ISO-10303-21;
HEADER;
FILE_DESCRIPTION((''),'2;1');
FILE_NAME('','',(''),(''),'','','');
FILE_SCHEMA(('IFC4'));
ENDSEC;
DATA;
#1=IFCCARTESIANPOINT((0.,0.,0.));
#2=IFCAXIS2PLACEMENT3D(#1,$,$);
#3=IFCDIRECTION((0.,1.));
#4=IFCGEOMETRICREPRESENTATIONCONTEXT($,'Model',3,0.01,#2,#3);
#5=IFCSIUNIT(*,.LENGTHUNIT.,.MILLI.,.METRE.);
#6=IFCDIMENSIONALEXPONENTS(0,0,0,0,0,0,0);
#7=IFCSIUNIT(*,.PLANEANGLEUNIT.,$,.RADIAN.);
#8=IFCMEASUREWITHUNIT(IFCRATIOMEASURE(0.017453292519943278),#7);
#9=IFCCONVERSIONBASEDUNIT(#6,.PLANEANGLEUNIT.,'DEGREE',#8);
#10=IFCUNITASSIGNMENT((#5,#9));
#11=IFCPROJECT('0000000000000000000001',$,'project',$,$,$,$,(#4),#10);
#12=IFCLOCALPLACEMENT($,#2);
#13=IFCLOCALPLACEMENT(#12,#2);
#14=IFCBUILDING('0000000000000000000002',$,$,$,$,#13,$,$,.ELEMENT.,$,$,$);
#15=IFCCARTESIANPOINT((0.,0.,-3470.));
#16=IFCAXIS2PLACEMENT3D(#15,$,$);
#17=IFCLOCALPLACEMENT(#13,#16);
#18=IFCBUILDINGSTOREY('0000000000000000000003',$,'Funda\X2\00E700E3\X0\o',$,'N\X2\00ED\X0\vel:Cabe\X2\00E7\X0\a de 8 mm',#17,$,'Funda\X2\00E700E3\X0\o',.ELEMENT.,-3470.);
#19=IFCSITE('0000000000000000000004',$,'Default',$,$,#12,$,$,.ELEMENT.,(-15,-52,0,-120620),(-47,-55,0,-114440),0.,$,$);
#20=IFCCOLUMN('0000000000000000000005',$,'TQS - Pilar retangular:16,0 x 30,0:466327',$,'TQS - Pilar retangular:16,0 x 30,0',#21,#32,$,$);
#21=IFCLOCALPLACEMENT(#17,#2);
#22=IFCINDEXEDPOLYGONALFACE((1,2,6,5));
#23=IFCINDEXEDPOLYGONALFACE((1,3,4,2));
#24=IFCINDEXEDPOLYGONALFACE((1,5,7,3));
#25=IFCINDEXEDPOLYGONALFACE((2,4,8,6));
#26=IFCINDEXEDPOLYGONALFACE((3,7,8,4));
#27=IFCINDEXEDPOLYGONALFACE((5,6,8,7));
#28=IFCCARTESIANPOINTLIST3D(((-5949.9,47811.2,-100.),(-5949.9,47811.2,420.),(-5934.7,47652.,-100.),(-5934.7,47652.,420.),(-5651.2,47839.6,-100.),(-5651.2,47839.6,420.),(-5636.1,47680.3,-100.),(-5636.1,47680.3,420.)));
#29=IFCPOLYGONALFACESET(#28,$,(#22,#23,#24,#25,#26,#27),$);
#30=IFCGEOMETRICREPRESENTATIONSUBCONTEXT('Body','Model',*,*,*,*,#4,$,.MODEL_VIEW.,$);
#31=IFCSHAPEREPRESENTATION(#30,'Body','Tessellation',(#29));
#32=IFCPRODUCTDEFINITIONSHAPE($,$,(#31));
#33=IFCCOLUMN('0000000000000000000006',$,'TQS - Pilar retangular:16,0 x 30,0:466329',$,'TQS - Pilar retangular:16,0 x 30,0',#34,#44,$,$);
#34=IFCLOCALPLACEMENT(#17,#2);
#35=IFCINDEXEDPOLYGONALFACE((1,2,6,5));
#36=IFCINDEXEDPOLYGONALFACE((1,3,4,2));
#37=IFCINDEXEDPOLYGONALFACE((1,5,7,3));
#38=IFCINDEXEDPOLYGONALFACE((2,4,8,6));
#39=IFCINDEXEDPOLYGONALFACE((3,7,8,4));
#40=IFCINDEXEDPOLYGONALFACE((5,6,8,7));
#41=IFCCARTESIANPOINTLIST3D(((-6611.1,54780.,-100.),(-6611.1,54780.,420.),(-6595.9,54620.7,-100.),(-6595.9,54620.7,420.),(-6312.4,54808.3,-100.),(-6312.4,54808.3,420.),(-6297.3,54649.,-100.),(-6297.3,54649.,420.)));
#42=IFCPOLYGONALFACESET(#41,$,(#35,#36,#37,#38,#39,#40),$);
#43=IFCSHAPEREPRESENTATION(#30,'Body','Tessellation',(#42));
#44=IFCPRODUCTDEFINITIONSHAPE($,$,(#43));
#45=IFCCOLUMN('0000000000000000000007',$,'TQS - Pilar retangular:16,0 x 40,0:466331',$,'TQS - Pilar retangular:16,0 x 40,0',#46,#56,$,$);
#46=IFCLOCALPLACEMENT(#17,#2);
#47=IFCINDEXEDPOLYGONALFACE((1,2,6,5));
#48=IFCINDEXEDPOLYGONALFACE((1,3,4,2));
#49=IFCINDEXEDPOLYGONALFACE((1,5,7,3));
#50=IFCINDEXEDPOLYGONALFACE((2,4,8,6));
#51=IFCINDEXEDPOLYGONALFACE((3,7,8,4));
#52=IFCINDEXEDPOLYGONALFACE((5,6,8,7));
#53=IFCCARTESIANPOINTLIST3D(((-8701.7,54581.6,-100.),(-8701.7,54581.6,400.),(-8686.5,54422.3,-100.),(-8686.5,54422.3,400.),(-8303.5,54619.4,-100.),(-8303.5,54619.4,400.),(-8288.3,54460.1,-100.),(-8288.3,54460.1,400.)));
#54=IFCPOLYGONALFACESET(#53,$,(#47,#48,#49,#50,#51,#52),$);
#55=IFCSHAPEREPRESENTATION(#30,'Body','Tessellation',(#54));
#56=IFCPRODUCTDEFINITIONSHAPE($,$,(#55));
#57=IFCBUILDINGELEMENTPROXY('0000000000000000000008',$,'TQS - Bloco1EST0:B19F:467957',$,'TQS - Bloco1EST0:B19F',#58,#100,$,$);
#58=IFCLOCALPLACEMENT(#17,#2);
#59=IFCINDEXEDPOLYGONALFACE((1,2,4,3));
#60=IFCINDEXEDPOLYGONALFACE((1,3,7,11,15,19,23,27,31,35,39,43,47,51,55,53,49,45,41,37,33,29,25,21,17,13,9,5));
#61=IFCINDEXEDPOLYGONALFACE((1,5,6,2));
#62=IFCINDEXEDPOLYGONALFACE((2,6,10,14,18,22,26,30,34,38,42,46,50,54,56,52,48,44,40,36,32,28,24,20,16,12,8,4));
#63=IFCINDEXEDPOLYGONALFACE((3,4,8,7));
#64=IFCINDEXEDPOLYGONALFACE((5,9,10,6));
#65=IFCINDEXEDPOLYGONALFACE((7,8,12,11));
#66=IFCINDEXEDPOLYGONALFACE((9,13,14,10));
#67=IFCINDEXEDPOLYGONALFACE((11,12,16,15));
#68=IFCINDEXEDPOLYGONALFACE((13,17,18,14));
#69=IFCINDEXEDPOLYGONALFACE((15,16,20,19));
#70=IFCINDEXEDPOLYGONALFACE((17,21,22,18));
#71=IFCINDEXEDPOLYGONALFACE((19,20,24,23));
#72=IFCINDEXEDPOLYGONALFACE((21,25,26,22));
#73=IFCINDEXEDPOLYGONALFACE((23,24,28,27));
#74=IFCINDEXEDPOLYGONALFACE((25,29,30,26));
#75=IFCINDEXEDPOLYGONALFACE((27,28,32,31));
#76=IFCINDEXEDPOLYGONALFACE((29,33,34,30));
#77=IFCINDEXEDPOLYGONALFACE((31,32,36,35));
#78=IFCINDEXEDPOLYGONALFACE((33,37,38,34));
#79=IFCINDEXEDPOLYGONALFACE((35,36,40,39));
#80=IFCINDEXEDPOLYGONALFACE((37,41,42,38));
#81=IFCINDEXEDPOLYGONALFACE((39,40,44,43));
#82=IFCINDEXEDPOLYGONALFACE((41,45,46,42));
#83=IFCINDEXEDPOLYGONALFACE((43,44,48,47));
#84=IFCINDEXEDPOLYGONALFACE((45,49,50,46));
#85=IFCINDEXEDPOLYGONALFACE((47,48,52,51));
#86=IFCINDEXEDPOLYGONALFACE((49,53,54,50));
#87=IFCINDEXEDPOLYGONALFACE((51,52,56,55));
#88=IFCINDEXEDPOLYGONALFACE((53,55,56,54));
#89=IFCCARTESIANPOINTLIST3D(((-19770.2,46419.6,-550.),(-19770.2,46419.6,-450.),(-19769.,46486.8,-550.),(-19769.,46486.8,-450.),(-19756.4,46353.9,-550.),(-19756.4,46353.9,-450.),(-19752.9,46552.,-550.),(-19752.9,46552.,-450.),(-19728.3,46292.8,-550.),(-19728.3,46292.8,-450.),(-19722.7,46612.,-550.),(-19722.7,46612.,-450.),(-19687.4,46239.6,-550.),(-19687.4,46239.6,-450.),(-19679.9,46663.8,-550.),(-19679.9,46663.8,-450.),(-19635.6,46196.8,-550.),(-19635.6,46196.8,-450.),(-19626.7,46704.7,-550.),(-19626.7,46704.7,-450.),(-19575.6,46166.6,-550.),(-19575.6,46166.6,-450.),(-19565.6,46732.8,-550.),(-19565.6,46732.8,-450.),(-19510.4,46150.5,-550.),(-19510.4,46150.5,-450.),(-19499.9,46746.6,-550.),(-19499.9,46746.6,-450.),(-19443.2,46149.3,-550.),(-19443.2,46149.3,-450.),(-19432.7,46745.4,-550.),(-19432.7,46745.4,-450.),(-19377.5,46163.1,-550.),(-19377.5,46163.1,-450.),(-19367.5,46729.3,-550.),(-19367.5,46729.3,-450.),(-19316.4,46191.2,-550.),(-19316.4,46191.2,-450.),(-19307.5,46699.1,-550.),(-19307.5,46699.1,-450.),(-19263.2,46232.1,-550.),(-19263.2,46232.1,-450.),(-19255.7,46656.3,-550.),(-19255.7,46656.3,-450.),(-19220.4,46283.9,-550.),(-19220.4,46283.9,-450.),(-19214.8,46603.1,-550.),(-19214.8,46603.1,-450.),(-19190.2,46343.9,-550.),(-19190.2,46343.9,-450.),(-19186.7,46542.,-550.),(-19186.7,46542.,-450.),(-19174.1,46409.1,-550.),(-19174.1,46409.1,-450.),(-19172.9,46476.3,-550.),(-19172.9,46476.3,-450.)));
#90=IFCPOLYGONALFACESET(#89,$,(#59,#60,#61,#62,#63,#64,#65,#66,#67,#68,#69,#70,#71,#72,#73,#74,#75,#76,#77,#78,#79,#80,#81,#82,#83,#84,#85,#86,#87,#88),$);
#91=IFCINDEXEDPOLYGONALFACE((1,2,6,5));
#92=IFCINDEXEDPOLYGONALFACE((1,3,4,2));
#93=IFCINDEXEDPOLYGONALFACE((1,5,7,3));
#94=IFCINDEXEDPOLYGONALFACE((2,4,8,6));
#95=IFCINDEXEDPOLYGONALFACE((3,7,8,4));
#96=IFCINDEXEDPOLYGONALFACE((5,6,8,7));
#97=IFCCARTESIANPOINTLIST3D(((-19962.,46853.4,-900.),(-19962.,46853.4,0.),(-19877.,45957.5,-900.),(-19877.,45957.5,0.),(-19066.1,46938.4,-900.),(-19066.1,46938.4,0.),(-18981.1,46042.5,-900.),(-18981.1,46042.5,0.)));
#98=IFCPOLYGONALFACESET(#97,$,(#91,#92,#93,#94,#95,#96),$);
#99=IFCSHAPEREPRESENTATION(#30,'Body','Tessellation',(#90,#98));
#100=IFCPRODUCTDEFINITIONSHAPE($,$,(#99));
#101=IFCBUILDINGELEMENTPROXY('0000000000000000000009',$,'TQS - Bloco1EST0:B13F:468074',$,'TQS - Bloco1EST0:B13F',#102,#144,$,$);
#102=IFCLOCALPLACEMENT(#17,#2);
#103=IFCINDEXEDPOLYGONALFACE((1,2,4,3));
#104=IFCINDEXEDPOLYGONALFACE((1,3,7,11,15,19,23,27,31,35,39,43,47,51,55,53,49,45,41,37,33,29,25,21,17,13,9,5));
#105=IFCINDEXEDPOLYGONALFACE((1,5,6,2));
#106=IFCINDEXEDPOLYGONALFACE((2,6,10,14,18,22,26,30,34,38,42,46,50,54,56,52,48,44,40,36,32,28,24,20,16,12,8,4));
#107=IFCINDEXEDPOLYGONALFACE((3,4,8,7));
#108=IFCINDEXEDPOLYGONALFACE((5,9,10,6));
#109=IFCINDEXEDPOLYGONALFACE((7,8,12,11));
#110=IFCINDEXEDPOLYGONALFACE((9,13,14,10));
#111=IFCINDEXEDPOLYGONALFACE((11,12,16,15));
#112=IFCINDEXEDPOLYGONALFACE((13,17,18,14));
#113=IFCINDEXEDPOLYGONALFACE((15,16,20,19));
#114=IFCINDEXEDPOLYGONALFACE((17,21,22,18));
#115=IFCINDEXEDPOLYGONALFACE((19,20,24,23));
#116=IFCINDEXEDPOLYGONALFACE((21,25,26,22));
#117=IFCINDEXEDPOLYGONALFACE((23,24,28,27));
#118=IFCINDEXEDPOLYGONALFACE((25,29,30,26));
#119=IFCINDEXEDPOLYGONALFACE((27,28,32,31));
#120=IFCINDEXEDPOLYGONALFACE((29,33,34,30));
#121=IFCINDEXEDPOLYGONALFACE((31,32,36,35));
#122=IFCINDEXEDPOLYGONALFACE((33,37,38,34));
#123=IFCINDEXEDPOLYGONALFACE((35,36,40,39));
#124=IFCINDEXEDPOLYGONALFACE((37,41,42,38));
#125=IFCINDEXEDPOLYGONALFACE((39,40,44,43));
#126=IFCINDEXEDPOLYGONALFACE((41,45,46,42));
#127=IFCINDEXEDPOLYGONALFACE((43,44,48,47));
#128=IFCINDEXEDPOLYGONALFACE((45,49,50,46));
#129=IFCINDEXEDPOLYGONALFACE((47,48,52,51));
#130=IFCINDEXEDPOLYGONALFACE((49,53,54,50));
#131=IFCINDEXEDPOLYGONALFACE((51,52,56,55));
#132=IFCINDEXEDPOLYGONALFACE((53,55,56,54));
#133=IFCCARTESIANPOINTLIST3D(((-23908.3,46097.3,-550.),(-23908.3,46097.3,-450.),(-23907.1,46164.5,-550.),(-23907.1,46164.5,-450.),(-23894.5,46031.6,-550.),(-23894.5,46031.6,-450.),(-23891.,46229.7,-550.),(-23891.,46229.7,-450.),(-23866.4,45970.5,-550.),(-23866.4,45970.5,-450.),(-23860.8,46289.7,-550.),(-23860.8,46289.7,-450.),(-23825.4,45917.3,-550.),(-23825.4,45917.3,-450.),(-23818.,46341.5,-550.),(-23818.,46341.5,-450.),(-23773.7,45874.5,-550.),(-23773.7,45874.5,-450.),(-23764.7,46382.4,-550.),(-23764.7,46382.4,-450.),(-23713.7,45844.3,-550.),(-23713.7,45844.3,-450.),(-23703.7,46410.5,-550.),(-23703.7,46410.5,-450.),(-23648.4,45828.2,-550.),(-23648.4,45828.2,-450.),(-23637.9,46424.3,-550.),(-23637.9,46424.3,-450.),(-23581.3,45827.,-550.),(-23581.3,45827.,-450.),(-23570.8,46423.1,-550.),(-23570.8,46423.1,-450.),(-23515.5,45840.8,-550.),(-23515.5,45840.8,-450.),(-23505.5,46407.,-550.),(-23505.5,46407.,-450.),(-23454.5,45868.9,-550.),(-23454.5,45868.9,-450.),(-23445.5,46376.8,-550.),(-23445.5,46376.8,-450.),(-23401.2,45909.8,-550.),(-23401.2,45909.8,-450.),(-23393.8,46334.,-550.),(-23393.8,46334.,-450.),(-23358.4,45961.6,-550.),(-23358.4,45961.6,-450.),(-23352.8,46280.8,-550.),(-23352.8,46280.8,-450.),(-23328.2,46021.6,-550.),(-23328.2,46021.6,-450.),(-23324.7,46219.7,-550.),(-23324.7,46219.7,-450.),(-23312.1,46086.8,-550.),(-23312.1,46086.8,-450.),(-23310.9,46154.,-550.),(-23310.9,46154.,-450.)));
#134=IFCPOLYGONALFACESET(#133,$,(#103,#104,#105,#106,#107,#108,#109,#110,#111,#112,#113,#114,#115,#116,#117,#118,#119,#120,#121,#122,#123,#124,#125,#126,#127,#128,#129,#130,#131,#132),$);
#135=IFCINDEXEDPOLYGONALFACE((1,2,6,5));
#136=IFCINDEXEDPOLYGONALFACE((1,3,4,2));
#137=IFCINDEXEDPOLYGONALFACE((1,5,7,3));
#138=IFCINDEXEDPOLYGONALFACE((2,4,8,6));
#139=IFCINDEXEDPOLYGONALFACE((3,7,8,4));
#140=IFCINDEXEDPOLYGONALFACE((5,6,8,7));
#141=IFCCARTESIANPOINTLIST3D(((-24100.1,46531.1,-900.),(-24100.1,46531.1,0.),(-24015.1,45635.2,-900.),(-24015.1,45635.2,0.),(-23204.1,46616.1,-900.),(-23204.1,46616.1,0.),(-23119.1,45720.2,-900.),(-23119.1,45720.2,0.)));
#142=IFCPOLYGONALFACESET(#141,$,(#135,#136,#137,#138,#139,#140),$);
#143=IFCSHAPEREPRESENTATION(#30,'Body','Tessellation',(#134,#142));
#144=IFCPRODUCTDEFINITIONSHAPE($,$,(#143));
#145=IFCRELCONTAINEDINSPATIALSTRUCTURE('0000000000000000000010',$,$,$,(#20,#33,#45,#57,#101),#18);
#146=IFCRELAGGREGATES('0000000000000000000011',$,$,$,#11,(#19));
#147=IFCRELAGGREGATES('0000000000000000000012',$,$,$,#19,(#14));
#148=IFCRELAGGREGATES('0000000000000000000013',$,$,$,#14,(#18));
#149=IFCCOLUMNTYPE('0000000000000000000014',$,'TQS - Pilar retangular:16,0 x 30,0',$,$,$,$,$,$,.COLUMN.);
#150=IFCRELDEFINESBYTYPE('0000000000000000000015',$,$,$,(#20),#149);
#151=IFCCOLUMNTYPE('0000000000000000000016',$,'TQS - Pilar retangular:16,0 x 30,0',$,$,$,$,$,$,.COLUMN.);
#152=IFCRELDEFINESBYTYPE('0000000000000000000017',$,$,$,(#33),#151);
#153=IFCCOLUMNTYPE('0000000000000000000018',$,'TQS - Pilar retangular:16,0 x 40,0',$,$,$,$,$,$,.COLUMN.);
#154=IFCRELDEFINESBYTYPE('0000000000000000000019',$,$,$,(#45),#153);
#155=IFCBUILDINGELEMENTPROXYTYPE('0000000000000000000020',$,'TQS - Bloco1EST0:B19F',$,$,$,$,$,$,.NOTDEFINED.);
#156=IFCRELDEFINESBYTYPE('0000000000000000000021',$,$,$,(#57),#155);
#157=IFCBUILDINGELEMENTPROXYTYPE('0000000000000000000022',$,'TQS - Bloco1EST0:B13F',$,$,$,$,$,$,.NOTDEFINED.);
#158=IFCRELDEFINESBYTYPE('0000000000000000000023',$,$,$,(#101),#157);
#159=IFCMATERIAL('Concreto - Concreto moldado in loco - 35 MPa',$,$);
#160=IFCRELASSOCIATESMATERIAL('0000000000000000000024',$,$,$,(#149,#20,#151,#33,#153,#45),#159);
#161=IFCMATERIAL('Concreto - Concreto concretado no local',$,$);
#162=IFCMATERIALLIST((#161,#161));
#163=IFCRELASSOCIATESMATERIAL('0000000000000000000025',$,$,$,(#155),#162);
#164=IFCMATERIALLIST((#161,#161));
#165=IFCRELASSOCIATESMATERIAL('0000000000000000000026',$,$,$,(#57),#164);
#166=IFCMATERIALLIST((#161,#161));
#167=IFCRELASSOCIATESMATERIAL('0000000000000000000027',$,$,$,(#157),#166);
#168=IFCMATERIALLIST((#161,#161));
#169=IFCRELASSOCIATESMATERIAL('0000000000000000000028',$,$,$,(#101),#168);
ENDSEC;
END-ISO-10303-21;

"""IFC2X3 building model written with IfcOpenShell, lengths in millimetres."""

from ifc_helpers import new_model, entity, si_unit, converted_unit, direction, frame, frame_2d, origin, origin_2d_with_axis, place, context, subcontext, project, spatial, rectangle, circle, extrude, source, transform, mapped, material, material_list, type_object, type_shapes, element, save


model = new_model("IFC2X3")

# Units and contexts
model_context = context("Model", 3, precision=0.01, world=origin(), true_north=direction((0.0, 1.0)))
body_context = subcontext(model_context, "Body", "Model", "MODEL_VIEW")
ifc_project = project(units=[si_unit("LENGTHUNIT", "METRE", prefix="MILLI"), converted_unit("PLANEANGLEUNIT", "DEGREE", entity("IfcRatioMeasure", 0.017453292519943278), si_unit("PLANEANGLEUNIT", "RADIAN"), dimensions=[0, 0, 0, 0, 0, 0, 0])], contexts=[model_context])

# Site, building, storey
site_placement = place(None, origin())
site = spatial("IfcSite", under=ifc_project, at=site_placement, Name="Default", CompositionType="ELEMENT", RefLatitude=(-15, -52, 0, -120620), RefLongitude=(-47, -55, 0, -114440), RefElevation=0.0)
building_placement = place(site_placement, origin())
building = spatial("IfcBuilding", under=site, at=building_placement, CompositionType="ELEMENT")
storey_placement = place(building_placement, frame((0.0, 0.0, -3470.0)))
storey = spatial("IfcBuildingStorey", under=building, at=storey_placement, Name="Fundação", ObjectType="Nível:Cabeça de 8 mm", LongName="Fundação", CompositionType="ELEMENT", Elevation=-3470.0)

# Columns
ifc_material_1 = material(Name="Concreto - Concreto moldado in loco - 35 MPa")
column_type_1 = type_object("IfcColumnType", Name="TQS - Pilar retangular:16,0 x 30,0", PredefinedType="COLUMN", material=ifc_material_1)
shared_shape_1 = source(origin(), body_context, "Body", "SweptSolid", [
    extrude(rectangle(XDim=300.0, YDim=160.0, at=frame_2d((0.0, 0.0), x_axis=(1.0, 0.0))), frame((-5793.0, 47745.8, -3570.0), z_axis=(0.0, 0.0, 1.0), x_axis=(-0.995529, -0.094456, 0.0)), (0.0, 0.0, 1.0), 520.0),
])
type_shapes(column_type_1, [shared_shape_1])
column_1_placement = place(storey_placement, frame((0.0, 0.0, 3470.0)))
element("IfcColumn", 1, at=column_1_placement, inside=storey, type_object=column_type_1, material=ifc_material_1, Name="TQS - Pilar retangular:16,0 x 30,0:466327", ObjectType="TQS - Pilar retangular:16,0 x 30,0", context=body_context, shape_type="MappedRepresentation", body=[
    mapped(shared_shape_1, transform((0.0, 0.0, 0.0), scale=1.0)),
])
column_type_2 = type_object("IfcColumnType", Name="TQS - Pilar retangular:16,0 x 30,0", PredefinedType="COLUMN", material=ifc_material_1)
shared_shape_2 = source(origin(), body_context, "Body", "SweptSolid", [
    extrude(rectangle(XDim=300.0, YDim=160.0, at=frame_2d((0.0, 0.0), x_axis=(1.0, 0.0))), frame((-6454.2, 54714.5, -3570.0), z_axis=(0.0, 0.0, 1.0), x_axis=(-0.995529, -0.094456, 0.0)), (0.0, 0.0, 1.0), 520.0),
])
type_shapes(column_type_2, [shared_shape_2])
column_2_placement = place(storey_placement, frame((0.0, 0.0, 3470.0)))
element("IfcColumn", 2, at=column_2_placement, inside=storey, type_object=column_type_2, material=ifc_material_1, Name="TQS - Pilar retangular:16,0 x 30,0:466329", ObjectType="TQS - Pilar retangular:16,0 x 30,0", context=body_context, shape_type="MappedRepresentation", body=[
    mapped(shared_shape_2, transform((0.0, 0.0, 0.0), scale=1.0)),
])
column_type_3 = type_object("IfcColumnType", Name="TQS - Pilar retangular:16,0 x 40,0", PredefinedType="COLUMN", material=ifc_material_1)
shared_shape_3 = source(origin(), body_context, "Body", "SweptSolid", [
    extrude(rectangle(XDim=400.0, YDim=160.0, at=origin_2d_with_axis()), frame((-8495.0, 54520.8, -3570.0), z_axis=(0.0, 0.0, 1.0), x_axis=(-0.995529, -0.094456, 0.0)), (0.0, 0.0, 1.0), 500.0),
])
type_shapes(column_type_3, [shared_shape_3])
column_3_placement = place(storey_placement, frame((0.0, 0.0, 3470.0)))
element("IfcColumn", 3, at=column_3_placement, inside=storey, type_object=column_type_3, material=ifc_material_1, Name="TQS - Pilar retangular:16,0 x 40,0:466331", ObjectType="TQS - Pilar retangular:16,0 x 40,0", context=body_context, shape_type="MappedRepresentation", body=[
    mapped(shared_shape_3, transform((0.0, 0.0, 0.0), scale=1.0)),
])

# Building element proxies
ifc_material_2 = material(Name="Concreto - Concreto concretado no local")
ifc_material_list_1 = material_list([ifc_material_2, ifc_material_2])
ifc_material_list_2 = material_list([ifc_material_2, ifc_material_2])
building_element_proxy_type_1 = type_object("IfcBuildingElementProxyType", Name="TQS - Bloco1EST0:B19F", PredefinedType="NOTDEFINED", material=ifc_material_list_2)
shared_shape_4 = source(origin(), body_context, "Body", "SweptSolid", [
    extrude(circle(Radius=300.0, at=frame_2d((0.0, 0.0), x_axis=(1.0, 0.0))), frame((0.0, 0.0, -550.0)), (0.0, 0.0, 1.0), 100.0),
    extrude(rectangle(XDim=900.0, YDim=900.0, at=origin_2d_with_axis()), frame((0.0, 0.0, -900.0), z_axis=(0.0, 0.0, 1.0), x_axis=(-1.0, 0.0, 0.0)), (0.0, 0.0, 1.0), 900.0),
])
type_shapes(building_element_proxy_type_1, [shared_shape_4])
proxy_1_placement = place(storey_placement, frame((-19471.5, 46448.0, 0.0), z_axis=(0.0, 0.0, 1.0), x_axis=(-0.094456, 0.995529, 0.0)))
element("IfcBuildingElementProxy", 4, at=proxy_1_placement, inside=storey, type_object=building_element_proxy_type_1, material=ifc_material_list_1, Name="TQS - Bloco1EST0:B19F:467957", ObjectType="TQS - Bloco1EST0:B19F", context=body_context, shape_type="MappedRepresentation", body=[
    mapped(shared_shape_4, transform((0.0, 0.0, 0.0), scale=1.0)),
])
ifc_material_list_3 = material_list([ifc_material_2, ifc_material_2])
ifc_material_list_4 = material_list([ifc_material_2, ifc_material_2])
building_element_proxy_type_2 = type_object("IfcBuildingElementProxyType", Name="TQS - Bloco1EST0:B13F", PredefinedType="NOTDEFINED", material=ifc_material_list_4)
shared_shape_5 = source(origin(), body_context, "Body", "SweptSolid", [
    extrude(circle(Radius=300.0, at=frame_2d((0.0, 0.0), x_axis=(1.0, 0.0))), frame((0.0, 0.0, -550.0)), (0.0, 0.0, 1.0), 100.0),
    extrude(rectangle(XDim=900.0, YDim=900.0, at=origin_2d_with_axis()), frame((0.0, 0.0, -900.0), z_axis=(0.0, 0.0, 1.0), x_axis=(-1.0, 0.0, 0.0)), (0.0, 0.0, 1.0), 900.0),
])
type_shapes(building_element_proxy_type_2, [shared_shape_5])
proxy_2_placement = place(storey_placement, frame((-23609.6, 46125.6, 0.0), z_axis=(0.0, 0.0, 1.0), x_axis=(-0.094456, 0.995529, 0.0)))
element("IfcBuildingElementProxy", 5, at=proxy_2_placement, inside=storey, type_object=building_element_proxy_type_2, material=ifc_material_list_3, Name="TQS - Bloco1EST0:B13F:468074", ObjectType="TQS - Bloco1EST0:B13F", context=body_context, shape_type="MappedRepresentation", body=[
    mapped(shared_shape_5, transform((0.0, 0.0, 0.0), scale=1.0)),
])

save(model, "model.ifc")
